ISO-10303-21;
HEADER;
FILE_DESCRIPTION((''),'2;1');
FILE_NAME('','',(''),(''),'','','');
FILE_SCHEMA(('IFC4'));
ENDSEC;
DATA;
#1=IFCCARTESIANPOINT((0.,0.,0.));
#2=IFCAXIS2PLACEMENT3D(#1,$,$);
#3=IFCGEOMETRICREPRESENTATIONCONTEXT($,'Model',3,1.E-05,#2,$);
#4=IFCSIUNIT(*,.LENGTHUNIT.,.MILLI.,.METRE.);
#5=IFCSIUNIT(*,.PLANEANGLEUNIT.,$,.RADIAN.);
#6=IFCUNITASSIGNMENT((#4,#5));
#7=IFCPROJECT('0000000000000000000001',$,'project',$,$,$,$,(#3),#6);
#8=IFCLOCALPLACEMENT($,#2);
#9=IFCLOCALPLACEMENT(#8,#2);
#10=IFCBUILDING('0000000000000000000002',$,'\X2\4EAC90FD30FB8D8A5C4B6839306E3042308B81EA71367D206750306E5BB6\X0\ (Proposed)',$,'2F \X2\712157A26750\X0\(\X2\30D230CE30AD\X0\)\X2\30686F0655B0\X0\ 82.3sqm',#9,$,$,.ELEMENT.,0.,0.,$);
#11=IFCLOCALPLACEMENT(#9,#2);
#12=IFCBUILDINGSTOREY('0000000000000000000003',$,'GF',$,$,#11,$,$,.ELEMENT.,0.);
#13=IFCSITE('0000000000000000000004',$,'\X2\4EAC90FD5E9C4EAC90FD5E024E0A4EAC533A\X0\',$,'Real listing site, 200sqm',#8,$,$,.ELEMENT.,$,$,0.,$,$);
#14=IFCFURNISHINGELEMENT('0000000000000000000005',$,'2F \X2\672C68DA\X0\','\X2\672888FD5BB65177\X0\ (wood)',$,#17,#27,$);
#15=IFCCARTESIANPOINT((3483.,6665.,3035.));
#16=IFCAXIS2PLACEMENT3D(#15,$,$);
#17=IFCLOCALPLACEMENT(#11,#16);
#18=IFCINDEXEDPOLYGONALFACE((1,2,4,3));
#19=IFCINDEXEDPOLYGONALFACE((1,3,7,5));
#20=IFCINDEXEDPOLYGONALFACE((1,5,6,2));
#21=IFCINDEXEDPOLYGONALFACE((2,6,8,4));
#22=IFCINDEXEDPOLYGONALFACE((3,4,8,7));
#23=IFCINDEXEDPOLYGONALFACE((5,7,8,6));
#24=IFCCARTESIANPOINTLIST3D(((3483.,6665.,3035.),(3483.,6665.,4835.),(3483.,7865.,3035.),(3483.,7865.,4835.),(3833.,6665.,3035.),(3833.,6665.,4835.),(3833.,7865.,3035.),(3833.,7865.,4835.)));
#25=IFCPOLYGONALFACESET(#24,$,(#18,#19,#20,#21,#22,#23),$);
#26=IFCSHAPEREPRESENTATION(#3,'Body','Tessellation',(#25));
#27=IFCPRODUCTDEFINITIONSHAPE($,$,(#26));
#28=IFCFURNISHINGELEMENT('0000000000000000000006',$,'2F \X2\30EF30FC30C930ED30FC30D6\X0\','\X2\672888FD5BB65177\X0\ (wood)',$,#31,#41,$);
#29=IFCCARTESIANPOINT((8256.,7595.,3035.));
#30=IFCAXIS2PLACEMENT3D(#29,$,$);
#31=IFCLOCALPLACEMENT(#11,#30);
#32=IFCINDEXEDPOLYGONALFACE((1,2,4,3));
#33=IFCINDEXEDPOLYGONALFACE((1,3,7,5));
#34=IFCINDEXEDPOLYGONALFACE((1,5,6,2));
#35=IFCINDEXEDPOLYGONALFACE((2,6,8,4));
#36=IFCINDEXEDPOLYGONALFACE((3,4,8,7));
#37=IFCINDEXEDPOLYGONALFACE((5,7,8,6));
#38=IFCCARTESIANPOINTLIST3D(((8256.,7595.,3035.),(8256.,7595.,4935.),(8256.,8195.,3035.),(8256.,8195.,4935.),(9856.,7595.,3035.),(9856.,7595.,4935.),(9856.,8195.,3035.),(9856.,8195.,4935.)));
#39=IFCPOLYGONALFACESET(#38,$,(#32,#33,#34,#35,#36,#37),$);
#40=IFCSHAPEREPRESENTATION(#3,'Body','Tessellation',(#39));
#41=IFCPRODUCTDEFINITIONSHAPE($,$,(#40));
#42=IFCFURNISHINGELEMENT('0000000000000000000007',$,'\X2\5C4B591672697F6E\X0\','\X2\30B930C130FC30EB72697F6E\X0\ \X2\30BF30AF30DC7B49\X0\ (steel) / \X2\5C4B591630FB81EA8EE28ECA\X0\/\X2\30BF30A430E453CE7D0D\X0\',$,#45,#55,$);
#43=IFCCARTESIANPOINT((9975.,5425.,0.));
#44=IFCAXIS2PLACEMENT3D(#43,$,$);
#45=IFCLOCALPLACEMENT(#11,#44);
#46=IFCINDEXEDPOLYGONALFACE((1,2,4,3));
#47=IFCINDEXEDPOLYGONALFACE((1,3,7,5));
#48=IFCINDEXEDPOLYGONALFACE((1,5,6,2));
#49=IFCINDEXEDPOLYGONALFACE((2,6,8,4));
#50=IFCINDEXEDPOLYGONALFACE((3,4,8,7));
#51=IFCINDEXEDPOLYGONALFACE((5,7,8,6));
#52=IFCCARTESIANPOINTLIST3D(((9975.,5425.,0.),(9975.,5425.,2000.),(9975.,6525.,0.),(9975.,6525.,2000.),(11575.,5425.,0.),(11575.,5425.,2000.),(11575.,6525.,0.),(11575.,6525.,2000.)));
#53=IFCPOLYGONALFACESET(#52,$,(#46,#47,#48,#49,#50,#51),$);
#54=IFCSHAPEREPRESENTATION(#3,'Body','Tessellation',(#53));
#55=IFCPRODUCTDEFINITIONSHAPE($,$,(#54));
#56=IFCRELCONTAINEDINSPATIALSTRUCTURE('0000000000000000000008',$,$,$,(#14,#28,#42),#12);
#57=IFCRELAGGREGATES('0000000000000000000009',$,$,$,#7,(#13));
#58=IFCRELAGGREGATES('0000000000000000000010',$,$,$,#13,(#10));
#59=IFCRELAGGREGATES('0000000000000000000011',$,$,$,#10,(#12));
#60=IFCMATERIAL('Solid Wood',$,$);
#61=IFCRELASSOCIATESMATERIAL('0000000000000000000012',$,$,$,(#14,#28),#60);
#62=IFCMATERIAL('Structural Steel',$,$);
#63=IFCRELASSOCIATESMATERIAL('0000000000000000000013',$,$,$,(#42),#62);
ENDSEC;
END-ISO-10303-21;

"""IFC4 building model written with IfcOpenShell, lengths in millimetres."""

from ifc_helpers import new_model, si_unit, frame, frame_2d, origin, place, context, project, spatial, rectangle, extrude, material, element, save


model = new_model("IFC4")

# Units and contexts
model_context = context("Model", 3, precision=1e-05, world=origin())
ifc_project = project(units=[si_unit("LENGTHUNIT", "METRE", prefix="MILLI"), si_unit("PLANEANGLEUNIT", "RADIAN")], contexts=[model_context])

# Site, building, storey
site_placement = place(None, origin())
site = spatial("IfcSite", under=ifc_project, at=site_placement, Name="京都府京都市上京区", ObjectType="Real listing site, 200sqm", CompositionType="ELEMENT", RefElevation=0.0)
building_placement = place(site_placement, origin())
building = spatial("IfcBuilding", under=site, at=building_placement, Name="京都・越屋根のある自然素材の家 (Proposed)", ObjectType="2F 無垢材(ヒノキ)と漆喰 82.3sqm", CompositionType="ELEMENT", ElevationOfRefHeight=0.0, ElevationOfTerrain=0.0)
storey_placement = place(building_placement, origin())
storey = spatial("IfcBuildingStorey", under=building, at=storey_placement, Name="GF", CompositionType="ELEMENT", Elevation=0.0)

# Shared definitions
ifc_material_1 = material(Name="Solid Wood")

# Shared definitions
ifc_material_2 = material(Name="Structural Steel")

# Furnishing elements
furnishing_1_placement = place(storey_placement, frame((3483.0, 6665.0, 3035.0)))
element("IfcFurnishingElement", 1, at=furnishing_1_placement, inside=storey, material=ifc_material_1, Name="2F 本棚", Description="木製家具 (wood)", context=model_context, shape_type="SweptSolid", body=[
    extrude(rectangle(XDim=350.0, YDim=1200.0, at=frame_2d((175.0, 600.0))), frame((3483.0, 6665.0, 3035.0)), (0.0, 0.0, 1.0), 1800.0),
])
furnishing_2_placement = place(storey_placement, frame((8256.0, 7595.0, 3035.0)))
element("IfcFurnishingElement", 2, at=furnishing_2_placement, inside=storey, material=ifc_material_1, Name="2F ワードローブ", Description="木製家具 (wood)", context=model_context, shape_type="SweptSolid", body=[
    extrude(rectangle(XDim=1600.0, YDim=600.0, at=frame_2d((800.0, 300.0))), frame((8256.0, 7595.0, 3035.0)), (0.0, 0.0, 1.0), 1900.0),
])
furnishing_3_placement = place(storey_placement, frame((9975.0, 5425.0, 0.0)))
element("IfcFurnishingElement", 3, at=furnishing_3_placement, inside=storey, material=ifc_material_2, Name="屋外物置", Description="スチール物置 タクボ等 (steel) / 屋外・自転車/タイヤ収納", context=model_context, shape_type="SweptSolid", body=[
    extrude(rectangle(XDim=1600.0, YDim=1100.0, at=frame_2d((800.0, 550.0))), frame((9975.0, 5425.0, 0.0)), (0.0, 0.0, 1.0), 2000.0),
])

save(model, "model.ifc")
